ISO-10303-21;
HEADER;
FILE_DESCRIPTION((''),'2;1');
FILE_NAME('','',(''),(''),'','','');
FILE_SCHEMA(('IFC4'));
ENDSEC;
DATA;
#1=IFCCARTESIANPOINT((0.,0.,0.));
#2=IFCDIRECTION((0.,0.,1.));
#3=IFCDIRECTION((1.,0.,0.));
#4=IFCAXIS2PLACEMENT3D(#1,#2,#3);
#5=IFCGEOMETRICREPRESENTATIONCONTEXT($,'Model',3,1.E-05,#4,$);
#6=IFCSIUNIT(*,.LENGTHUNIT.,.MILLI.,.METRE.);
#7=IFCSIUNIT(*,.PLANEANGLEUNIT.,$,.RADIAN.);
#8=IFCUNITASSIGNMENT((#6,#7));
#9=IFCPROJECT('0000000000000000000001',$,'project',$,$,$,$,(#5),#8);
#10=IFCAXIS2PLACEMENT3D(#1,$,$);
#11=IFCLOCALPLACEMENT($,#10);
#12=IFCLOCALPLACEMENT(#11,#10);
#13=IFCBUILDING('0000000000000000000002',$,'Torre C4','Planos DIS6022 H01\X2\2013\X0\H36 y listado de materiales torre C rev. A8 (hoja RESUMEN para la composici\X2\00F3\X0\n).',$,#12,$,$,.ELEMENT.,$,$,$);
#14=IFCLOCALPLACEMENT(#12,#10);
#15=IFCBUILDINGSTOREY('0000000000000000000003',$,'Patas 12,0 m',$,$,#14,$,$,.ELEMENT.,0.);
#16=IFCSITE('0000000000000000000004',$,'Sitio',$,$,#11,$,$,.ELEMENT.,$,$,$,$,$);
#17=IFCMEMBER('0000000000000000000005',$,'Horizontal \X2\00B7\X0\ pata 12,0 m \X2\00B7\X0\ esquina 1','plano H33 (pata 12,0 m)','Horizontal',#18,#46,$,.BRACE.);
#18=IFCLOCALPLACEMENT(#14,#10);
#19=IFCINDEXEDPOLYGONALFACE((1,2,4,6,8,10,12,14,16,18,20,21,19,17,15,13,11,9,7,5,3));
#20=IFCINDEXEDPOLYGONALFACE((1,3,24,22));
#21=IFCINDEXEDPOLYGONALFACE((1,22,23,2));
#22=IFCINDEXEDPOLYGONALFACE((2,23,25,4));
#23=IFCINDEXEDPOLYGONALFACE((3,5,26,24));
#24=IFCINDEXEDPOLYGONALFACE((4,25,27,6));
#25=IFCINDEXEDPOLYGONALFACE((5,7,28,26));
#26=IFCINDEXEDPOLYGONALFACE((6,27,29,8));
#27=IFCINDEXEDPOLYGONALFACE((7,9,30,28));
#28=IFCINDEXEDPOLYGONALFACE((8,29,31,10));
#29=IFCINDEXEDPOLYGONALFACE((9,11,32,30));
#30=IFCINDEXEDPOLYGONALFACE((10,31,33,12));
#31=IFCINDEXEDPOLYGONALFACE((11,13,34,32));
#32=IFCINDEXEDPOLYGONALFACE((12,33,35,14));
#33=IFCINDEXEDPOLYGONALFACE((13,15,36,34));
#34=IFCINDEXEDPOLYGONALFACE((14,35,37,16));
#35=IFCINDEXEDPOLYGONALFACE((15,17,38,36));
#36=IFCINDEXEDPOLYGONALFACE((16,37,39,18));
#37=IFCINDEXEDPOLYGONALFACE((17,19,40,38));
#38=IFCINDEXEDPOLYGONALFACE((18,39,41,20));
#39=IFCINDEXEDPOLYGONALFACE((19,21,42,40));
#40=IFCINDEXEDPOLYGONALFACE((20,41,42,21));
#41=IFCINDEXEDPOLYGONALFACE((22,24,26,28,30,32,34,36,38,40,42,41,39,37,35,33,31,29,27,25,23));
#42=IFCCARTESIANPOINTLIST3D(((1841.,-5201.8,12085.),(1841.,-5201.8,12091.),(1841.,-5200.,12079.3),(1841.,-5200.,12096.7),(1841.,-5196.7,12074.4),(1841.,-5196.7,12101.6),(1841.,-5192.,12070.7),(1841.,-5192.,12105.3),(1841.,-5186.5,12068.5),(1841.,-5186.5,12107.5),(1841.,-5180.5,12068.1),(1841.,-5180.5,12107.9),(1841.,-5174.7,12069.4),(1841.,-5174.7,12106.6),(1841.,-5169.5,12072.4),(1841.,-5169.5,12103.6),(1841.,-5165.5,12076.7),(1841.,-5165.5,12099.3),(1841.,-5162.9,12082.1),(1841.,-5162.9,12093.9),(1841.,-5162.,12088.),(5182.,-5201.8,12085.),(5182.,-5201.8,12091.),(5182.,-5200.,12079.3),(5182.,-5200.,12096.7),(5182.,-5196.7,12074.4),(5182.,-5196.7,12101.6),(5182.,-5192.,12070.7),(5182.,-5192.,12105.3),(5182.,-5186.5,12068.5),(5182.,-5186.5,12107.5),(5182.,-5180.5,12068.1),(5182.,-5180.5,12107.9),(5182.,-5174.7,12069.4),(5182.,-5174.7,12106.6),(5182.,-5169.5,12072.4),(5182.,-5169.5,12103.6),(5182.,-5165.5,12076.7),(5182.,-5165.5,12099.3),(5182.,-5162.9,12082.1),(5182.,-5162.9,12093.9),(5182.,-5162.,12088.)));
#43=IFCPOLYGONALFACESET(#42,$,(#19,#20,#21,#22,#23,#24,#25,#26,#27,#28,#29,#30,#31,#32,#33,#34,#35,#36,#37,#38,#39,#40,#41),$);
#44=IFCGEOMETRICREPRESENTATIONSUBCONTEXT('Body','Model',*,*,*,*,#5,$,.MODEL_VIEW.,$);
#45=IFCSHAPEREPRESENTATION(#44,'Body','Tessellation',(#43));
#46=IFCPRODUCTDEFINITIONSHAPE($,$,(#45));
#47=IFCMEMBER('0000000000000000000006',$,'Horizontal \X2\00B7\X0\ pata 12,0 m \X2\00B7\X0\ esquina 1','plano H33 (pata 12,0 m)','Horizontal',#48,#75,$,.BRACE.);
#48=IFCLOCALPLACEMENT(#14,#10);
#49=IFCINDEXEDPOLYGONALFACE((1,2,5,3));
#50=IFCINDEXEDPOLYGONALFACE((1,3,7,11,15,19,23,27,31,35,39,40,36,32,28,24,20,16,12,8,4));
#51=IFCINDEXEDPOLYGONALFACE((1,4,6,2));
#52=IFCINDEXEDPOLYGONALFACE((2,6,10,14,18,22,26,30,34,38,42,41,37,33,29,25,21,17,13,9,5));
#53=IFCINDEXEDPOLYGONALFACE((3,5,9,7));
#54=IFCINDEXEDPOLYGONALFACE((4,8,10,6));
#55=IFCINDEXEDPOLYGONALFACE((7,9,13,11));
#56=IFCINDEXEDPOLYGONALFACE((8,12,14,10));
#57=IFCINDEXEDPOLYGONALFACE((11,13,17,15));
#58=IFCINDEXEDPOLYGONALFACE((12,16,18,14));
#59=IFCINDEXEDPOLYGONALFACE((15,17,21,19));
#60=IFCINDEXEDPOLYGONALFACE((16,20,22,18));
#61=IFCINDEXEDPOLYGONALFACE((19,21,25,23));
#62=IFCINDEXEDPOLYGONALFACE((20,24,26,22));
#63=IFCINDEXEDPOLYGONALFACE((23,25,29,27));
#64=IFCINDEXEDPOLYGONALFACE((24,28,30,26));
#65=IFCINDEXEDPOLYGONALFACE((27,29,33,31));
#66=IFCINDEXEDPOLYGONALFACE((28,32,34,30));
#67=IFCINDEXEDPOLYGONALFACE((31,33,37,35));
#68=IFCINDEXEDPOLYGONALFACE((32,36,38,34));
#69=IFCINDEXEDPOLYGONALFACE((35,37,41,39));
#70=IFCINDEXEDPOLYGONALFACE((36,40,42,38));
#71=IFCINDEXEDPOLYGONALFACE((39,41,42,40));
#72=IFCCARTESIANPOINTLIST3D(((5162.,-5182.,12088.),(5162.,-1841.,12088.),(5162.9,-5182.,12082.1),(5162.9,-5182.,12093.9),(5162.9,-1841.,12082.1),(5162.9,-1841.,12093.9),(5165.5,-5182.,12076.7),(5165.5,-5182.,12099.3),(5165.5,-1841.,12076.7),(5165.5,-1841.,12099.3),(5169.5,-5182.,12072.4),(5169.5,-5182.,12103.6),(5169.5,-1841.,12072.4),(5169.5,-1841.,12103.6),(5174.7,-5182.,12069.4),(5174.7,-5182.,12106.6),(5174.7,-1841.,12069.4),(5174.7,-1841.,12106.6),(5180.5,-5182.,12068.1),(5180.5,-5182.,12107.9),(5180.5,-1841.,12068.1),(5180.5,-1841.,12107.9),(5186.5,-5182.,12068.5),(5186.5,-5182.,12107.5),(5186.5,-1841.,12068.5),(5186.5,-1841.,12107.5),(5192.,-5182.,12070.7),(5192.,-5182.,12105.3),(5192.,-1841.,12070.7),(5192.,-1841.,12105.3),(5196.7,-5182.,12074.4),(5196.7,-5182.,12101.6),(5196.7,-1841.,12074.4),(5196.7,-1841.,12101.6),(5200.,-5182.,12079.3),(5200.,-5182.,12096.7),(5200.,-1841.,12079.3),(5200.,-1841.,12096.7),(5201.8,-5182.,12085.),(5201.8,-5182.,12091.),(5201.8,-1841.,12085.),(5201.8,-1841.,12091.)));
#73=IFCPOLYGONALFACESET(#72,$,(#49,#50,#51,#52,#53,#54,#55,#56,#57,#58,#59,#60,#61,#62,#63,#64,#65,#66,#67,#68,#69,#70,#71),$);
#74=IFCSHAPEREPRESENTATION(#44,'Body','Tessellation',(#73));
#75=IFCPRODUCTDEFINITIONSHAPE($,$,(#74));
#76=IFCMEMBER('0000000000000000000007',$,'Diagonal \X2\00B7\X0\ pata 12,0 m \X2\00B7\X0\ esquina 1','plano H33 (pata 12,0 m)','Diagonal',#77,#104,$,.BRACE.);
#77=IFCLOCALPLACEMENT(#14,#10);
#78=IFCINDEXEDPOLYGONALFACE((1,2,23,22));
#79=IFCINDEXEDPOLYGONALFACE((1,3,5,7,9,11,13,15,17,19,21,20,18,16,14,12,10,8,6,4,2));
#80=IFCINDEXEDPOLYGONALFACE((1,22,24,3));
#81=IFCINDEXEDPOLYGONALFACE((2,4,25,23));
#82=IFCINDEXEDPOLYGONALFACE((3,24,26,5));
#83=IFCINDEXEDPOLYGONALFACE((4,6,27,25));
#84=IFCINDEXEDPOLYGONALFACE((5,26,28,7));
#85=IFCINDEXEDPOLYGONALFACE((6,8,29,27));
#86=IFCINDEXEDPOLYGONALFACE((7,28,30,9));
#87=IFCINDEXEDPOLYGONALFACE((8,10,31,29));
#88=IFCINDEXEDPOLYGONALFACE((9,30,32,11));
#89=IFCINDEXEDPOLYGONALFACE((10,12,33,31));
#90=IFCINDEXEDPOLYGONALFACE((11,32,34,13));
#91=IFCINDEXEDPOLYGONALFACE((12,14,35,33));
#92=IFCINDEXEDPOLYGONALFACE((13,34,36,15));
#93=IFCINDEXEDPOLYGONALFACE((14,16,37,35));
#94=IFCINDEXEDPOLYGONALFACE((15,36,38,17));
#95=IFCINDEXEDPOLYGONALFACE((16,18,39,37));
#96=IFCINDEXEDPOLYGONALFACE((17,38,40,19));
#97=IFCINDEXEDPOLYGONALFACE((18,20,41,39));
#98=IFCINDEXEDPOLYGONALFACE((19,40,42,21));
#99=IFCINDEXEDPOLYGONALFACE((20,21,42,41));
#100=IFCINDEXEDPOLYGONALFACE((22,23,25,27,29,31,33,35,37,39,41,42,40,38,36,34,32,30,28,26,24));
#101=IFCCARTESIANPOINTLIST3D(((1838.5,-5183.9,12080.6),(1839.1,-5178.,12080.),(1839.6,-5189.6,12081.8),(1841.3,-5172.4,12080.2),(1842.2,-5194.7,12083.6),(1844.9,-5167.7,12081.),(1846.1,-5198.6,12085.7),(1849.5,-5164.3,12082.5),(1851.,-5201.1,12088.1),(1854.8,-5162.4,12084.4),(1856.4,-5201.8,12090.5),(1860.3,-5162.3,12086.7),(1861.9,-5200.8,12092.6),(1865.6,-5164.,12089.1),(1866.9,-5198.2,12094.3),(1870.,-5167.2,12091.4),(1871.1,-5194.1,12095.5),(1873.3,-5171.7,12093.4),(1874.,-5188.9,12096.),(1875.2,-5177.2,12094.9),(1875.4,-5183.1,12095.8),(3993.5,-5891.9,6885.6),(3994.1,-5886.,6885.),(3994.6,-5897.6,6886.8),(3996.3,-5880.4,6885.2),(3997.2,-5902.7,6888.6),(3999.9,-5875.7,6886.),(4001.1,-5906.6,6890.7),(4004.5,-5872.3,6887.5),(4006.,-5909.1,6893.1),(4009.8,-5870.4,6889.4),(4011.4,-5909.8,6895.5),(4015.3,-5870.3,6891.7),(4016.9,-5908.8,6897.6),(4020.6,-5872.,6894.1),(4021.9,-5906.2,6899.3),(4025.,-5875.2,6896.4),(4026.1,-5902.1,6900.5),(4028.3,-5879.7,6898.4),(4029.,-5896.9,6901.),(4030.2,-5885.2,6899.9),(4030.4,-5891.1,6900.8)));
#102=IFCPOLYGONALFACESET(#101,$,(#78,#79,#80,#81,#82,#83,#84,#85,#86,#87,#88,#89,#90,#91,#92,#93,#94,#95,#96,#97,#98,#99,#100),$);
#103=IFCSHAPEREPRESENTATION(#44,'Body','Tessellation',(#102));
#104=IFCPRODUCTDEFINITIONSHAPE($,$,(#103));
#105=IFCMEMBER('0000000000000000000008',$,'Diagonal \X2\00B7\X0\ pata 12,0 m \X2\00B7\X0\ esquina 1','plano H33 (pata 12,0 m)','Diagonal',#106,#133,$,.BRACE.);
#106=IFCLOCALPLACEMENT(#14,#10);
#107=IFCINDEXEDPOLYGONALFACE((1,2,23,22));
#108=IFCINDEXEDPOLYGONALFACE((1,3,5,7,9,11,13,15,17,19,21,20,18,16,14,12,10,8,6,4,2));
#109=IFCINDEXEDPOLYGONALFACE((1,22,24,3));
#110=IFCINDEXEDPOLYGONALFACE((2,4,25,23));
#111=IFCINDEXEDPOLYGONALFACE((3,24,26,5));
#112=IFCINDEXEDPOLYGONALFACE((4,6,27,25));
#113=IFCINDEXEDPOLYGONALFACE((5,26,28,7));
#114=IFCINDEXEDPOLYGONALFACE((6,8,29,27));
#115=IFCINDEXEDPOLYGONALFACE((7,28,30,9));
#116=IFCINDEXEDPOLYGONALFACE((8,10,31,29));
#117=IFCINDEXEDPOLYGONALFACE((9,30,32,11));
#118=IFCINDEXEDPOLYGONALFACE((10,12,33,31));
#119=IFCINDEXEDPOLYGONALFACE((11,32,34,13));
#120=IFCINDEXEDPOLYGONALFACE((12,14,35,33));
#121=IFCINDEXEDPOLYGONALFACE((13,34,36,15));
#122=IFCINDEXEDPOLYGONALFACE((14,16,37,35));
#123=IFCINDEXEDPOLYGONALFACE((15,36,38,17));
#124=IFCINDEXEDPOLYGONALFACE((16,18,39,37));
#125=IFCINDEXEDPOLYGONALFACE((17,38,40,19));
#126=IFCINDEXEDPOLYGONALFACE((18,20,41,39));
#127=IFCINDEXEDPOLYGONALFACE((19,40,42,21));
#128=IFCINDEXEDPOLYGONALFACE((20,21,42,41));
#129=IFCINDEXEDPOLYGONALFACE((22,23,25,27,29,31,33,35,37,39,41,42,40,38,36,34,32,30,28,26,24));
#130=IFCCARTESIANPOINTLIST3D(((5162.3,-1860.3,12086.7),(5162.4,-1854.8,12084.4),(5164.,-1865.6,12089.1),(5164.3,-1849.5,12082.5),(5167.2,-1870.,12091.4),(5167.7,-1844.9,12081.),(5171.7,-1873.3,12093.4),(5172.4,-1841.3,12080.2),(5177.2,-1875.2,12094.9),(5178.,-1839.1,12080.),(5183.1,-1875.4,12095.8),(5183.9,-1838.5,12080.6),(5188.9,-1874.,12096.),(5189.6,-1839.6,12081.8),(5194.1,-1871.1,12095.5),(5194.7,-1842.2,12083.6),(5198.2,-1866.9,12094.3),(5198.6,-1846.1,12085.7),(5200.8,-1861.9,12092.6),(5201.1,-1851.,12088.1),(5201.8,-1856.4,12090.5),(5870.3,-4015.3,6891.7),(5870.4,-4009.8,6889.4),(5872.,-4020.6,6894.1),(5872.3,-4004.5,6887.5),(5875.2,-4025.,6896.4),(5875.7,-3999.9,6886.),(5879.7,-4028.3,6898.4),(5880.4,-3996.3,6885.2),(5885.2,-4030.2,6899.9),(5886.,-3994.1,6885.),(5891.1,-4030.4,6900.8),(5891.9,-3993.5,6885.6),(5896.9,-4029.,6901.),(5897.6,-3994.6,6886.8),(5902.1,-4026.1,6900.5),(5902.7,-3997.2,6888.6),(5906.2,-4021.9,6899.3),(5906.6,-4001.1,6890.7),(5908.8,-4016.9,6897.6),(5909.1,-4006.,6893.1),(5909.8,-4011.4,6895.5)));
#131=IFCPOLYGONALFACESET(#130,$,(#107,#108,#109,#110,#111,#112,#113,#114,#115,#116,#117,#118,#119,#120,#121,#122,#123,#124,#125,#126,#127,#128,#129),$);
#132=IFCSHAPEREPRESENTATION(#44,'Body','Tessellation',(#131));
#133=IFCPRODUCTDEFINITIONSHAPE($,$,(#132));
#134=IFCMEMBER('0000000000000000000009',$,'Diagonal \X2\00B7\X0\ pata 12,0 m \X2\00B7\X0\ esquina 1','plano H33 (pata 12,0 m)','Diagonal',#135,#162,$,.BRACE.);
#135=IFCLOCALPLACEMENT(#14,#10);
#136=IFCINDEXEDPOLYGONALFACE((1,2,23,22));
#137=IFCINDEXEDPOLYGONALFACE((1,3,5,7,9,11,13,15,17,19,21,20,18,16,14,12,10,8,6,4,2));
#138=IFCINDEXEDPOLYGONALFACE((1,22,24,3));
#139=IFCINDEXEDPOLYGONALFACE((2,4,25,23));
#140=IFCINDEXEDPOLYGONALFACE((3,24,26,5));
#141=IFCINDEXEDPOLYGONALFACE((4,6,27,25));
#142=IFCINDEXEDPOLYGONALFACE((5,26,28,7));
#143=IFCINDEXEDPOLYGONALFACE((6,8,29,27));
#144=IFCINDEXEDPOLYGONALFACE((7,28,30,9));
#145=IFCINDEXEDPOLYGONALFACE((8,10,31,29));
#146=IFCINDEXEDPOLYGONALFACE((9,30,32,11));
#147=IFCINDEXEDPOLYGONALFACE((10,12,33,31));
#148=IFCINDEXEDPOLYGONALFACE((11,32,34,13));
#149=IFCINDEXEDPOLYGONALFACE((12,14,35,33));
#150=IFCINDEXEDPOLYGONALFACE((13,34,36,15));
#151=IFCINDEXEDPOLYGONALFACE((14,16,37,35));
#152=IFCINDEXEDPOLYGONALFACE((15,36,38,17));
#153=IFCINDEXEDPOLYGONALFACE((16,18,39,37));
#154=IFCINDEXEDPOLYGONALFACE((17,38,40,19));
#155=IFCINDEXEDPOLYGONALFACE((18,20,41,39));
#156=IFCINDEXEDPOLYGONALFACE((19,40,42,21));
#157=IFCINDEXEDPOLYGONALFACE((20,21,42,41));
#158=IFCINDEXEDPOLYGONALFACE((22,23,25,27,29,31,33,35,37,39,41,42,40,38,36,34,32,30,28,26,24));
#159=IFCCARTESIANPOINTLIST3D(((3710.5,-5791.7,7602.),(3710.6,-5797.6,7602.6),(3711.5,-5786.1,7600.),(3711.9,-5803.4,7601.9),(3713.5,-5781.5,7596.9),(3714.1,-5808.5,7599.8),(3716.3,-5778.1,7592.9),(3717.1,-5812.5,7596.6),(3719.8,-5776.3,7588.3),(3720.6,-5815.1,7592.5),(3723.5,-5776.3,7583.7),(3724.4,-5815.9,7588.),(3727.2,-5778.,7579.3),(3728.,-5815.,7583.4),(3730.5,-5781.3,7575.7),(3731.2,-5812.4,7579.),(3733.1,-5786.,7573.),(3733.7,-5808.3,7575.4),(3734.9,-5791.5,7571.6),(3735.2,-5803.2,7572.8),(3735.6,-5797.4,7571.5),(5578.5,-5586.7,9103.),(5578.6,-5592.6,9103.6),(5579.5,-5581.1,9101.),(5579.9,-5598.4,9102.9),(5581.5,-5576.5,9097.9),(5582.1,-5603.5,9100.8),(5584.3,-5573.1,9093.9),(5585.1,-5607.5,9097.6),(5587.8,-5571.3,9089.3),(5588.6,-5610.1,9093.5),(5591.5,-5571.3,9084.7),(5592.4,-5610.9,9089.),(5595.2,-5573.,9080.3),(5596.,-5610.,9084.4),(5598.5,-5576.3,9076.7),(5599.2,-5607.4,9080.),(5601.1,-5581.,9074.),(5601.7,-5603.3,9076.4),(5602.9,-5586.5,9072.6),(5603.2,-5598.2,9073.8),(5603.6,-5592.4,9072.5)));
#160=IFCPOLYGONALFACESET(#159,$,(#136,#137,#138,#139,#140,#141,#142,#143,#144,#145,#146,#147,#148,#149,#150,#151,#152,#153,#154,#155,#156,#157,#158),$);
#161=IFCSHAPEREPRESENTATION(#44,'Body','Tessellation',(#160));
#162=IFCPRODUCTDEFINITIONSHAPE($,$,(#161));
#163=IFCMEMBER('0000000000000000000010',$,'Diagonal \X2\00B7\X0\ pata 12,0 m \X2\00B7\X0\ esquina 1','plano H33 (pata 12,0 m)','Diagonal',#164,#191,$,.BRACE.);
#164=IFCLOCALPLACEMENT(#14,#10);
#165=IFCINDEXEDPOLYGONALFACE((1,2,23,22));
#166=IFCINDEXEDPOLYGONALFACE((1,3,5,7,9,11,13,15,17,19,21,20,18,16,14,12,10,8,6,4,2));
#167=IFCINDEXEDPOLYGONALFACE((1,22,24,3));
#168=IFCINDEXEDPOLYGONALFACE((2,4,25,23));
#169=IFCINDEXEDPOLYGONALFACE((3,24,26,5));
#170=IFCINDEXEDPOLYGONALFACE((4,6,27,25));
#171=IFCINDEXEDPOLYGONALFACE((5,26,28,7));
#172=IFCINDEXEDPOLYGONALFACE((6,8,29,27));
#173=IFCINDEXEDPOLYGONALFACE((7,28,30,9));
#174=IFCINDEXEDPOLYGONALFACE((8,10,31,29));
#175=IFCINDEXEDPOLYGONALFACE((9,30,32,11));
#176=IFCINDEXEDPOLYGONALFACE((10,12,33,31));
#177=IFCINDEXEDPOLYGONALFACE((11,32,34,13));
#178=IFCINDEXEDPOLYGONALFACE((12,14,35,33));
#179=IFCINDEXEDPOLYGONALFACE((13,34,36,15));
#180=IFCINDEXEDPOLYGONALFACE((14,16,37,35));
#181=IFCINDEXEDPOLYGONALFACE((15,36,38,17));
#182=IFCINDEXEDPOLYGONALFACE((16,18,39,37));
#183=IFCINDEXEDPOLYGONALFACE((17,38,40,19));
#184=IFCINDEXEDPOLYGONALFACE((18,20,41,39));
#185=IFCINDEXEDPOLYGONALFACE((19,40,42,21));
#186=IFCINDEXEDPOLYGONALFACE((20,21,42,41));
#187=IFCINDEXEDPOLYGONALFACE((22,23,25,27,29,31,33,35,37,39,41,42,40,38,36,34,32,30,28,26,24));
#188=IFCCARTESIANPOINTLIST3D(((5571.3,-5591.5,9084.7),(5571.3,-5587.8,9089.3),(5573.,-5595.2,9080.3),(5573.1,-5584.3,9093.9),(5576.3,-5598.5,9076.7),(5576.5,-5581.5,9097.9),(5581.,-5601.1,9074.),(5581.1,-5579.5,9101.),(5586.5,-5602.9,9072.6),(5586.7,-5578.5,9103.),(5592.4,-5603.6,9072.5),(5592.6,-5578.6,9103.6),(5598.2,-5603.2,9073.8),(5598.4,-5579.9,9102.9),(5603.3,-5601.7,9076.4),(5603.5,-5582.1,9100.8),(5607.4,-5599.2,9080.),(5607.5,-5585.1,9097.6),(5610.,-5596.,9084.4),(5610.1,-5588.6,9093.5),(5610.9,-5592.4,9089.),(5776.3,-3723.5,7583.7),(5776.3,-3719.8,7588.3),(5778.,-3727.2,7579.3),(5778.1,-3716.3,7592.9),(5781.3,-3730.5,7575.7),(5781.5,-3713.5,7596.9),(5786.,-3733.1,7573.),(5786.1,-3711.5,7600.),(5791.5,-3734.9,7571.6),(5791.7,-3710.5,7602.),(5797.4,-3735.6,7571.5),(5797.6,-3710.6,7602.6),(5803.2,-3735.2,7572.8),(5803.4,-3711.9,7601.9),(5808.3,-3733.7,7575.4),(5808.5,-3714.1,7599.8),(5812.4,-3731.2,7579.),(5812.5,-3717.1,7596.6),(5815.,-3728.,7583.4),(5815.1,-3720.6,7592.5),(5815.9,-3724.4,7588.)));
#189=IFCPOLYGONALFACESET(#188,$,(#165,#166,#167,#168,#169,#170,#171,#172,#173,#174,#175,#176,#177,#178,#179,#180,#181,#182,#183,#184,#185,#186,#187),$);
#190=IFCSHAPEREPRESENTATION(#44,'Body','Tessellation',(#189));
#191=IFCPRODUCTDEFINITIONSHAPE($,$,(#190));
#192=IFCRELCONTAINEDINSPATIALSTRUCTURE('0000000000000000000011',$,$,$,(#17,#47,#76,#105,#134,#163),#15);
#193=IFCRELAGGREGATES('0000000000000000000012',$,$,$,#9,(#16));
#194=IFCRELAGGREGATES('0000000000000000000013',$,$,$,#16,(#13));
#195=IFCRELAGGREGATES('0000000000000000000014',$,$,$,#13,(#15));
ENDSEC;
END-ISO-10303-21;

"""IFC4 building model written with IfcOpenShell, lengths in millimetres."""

from ifc_helpers import new_model, si_unit, frame, origin, origin_with_axes, place, context, subcontext, project, spatial, circle, extrude, element, save


model = new_model("IFC4")

# Units and contexts
model_context = context("Model", 3, precision=1e-05, world=origin_with_axes())
body_context = subcontext(model_context, "Body", "Model", "MODEL_VIEW")
ifc_project = project(units=[si_unit("LENGTHUNIT", "METRE", prefix="MILLI"), si_unit("PLANEANGLEUNIT", "RADIAN")], contexts=[model_context])

# Site, building, storey
site_placement = place(None, origin())
site = spatial("IfcSite", under=ifc_project, at=site_placement, Name="Sitio", CompositionType="ELEMENT")
building_placement = place(site_placement, origin())
building = spatial("IfcBuilding", under=site, at=building_placement, Name="Torre C4", Description="Planos DIS6022 H01–H36 y listado de materiales torre C rev. A8 (hoja RESUMEN para la composición).", CompositionType="ELEMENT")
storey_placement = place(building_placement, origin())
storey = spatial("IfcBuildingStorey", under=building, at=storey_placement, Name="Patas 12,0 m", CompositionType="ELEMENT", Elevation=0.0)

# Members
for number, where, z_axis, x_axis, name in (
    (1, (5182.0, -5182.0, 12088.0), (-1.0, 0.0, 0.0), (0.0, 1.0, 0.0), "Horizontal · pata 12,0 m · esquina 1"),
    (2, (5182.0, -5182.0, 12088.0), (0.0, 1.0, 0.0), (-1.0, 0.0, 0.0), "Horizontal · pata 12,0 m · esquina 1"),
):
    element("IfcMember", number, at=place(storey_placement, frame(where, z_axis=z_axis, x_axis=x_axis)), inside=storey, Name=name, Description="plano H33 (pata 12,0 m)", ObjectType="Horizontal", PredefinedType="BRACE", context=body_context, shape_type="SweptSolid", body=[
        extrude(circle(Radius=20.0), None, (0.0, 0.0, 1.0), 3341.0),
    ])
for number, where, z_axis, x_axis, name in (
    (3, (1857.0, -5182.0, 12088.0), (0.380163, -0.124898, -0.916448), (-0.374625, 0.885134, -0.276033), "Diagonal · pata 12,0 m · esquina 1"),
    (4, (5182.0, -1857.0, 12088.0), (0.124898, -0.380163, -0.916448), (-0.885134, 0.374625, -0.276033), "Diagonal · pata 12,0 m · esquina 1"),
):
    element("IfcMember", number, at=place(storey_placement, frame(where, z_axis=z_axis, x_axis=x_axis)), inside=storey, Name=name, Description="plano H33 (pata 12,0 m)", ObjectType="Diagonal", PredefinedType="BRACE", context=body_context, shape_type="SweptSolid", body=[
        extrude(circle(Radius=20.0), None, (0.0, 0.0, 1.0), 5668.6),
    ])
for number, where, z_axis, x_axis, name in (
    (5, (5591.0, -5591.0, 9088.0), (-0.776687, -0.085236, -0.624093), (-0.334252, 0.895564, 0.293666), "Diagonal · pata 12,0 m · esquina 1"),
    (6, (5591.0, -5591.0, 9088.0), (0.085236, 0.776687, -0.624093), (-0.895564, 0.334252, 0.293666), "Diagonal · pata 12,0 m · esquina 1"),
):
    element("IfcMember", number, at=place(storey_placement, frame(where, z_axis=z_axis, x_axis=x_axis)), inside=storey, Name=name, Description="plano H33 (pata 12,0 m)", ObjectType="Diagonal", PredefinedType="BRACE", context=body_context, shape_type="SweptSolid", body=[
        extrude(circle(Radius=20.0), None, (0.0, 0.0, 1.0), 2405.1),
    ])

save(model, "model.ifc")
